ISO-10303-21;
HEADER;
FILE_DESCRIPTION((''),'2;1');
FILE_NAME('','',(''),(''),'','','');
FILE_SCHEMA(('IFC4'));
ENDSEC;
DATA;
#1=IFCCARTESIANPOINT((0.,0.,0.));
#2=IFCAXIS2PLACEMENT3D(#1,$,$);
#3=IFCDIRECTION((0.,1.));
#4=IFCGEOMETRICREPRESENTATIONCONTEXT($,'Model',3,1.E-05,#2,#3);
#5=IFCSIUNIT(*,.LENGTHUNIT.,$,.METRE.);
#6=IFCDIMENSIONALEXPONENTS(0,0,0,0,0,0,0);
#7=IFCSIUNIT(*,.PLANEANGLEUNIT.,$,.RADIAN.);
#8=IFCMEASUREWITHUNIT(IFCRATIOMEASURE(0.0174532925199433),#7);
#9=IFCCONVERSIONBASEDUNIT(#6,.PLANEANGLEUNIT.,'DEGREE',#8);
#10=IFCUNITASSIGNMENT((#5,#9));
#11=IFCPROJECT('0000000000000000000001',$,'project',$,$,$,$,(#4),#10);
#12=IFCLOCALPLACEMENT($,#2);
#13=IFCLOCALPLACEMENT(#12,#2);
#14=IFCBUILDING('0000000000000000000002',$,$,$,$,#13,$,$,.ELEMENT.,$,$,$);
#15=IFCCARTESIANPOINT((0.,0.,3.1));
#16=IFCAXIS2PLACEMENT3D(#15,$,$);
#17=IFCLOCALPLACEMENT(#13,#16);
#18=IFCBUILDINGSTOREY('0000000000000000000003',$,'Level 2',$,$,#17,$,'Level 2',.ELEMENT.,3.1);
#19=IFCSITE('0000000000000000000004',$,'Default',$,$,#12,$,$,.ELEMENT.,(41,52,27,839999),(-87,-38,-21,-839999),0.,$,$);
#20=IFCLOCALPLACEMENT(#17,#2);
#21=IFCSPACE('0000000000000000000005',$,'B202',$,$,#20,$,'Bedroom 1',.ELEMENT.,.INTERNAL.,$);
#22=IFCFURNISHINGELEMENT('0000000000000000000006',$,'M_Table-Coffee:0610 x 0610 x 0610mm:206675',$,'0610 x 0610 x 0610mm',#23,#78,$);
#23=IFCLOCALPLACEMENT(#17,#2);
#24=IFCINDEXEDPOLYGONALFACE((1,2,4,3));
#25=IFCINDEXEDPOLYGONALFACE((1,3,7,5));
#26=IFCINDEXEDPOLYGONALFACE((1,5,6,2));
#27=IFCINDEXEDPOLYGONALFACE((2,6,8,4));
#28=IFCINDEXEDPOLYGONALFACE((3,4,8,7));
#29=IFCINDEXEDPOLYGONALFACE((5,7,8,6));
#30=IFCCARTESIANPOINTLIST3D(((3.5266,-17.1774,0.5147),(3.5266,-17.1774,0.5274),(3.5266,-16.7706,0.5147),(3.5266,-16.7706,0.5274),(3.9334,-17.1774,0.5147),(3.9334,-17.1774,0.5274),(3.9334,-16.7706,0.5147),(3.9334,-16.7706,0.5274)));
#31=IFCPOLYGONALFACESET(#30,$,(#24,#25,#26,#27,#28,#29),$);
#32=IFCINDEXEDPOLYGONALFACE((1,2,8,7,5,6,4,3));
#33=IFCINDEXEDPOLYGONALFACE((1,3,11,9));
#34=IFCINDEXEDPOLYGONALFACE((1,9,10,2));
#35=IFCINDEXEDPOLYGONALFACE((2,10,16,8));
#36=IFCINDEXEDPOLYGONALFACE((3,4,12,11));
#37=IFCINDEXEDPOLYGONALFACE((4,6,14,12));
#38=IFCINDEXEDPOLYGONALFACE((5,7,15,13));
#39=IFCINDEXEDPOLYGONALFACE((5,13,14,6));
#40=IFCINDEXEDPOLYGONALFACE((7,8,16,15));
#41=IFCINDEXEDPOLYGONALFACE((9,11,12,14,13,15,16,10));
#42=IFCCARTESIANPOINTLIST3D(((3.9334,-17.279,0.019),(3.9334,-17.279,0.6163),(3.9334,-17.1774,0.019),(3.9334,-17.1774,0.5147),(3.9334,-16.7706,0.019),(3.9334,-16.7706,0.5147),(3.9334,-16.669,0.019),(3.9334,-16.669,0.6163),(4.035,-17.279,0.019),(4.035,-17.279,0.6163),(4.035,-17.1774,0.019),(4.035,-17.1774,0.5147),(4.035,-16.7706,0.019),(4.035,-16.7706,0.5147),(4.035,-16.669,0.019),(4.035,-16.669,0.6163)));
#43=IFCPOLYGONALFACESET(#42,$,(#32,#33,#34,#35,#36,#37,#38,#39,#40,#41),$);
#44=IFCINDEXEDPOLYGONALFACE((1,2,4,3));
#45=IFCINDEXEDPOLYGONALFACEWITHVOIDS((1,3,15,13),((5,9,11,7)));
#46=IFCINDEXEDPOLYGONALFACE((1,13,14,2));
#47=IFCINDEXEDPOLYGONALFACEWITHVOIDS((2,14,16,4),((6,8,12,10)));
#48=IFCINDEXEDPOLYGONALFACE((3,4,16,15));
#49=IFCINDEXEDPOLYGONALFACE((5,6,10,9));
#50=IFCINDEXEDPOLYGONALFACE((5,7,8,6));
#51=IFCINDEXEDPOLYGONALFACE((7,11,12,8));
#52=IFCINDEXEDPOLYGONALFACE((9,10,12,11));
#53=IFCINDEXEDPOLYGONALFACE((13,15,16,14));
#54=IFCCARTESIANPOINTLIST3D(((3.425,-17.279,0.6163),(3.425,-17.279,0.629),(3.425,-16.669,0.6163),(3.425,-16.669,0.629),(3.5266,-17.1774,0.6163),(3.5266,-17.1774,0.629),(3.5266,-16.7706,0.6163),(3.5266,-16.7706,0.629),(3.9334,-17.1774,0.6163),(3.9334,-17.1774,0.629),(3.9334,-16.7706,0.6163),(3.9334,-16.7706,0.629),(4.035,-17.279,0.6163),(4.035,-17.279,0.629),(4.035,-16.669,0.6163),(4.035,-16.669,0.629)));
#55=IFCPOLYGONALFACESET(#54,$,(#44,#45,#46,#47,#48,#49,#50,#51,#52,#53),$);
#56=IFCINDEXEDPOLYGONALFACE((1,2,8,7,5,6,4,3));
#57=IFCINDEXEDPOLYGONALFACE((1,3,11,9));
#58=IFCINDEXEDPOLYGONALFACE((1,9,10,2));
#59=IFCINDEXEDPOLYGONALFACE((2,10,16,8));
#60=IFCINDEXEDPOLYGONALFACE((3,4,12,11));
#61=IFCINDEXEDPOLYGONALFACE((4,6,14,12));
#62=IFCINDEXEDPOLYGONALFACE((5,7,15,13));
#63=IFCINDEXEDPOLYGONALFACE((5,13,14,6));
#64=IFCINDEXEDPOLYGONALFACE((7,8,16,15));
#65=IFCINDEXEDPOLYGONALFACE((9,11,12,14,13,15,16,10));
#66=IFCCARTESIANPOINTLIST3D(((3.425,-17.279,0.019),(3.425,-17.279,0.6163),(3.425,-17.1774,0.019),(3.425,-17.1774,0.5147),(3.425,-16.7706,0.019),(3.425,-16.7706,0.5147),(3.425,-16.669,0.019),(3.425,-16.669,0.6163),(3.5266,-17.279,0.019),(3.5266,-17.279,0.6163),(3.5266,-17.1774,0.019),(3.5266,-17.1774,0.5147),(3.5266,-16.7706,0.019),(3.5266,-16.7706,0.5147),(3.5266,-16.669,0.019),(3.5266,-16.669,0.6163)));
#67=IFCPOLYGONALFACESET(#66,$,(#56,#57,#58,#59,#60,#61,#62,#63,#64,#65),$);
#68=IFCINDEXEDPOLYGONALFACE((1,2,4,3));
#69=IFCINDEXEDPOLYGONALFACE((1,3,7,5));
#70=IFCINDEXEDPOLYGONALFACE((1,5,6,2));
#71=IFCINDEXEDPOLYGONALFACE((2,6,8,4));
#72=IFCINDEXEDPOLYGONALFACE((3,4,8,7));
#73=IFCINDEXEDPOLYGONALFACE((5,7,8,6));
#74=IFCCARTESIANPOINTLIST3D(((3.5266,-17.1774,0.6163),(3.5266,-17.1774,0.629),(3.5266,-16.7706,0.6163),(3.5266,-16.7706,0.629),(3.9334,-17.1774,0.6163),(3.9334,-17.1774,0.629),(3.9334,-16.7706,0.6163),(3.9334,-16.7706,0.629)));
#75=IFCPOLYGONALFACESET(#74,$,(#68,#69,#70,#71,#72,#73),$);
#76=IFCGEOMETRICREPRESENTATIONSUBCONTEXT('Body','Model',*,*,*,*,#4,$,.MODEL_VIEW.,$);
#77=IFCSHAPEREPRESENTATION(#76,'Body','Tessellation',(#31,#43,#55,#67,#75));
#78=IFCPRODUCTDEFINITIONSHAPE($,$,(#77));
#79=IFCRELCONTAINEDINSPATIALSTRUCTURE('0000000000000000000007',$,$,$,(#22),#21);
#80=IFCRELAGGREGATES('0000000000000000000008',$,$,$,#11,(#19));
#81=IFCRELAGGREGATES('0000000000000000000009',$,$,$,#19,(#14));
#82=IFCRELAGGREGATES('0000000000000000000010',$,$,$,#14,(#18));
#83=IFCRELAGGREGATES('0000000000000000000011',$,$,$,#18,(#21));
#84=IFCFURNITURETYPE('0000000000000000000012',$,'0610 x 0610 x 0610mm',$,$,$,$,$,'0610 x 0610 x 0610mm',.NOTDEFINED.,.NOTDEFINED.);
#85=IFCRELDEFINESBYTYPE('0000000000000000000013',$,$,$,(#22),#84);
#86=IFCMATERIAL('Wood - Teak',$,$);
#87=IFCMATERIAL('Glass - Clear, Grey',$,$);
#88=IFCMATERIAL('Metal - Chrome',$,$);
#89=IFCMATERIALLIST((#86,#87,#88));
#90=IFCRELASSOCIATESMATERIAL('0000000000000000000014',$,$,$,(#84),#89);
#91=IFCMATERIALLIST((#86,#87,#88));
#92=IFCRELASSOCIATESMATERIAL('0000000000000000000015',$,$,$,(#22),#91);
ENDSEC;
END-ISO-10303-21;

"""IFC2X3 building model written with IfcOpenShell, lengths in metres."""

from ifc_helpers import new_model, entity, si_unit, converted_unit, direction, frame, origin, origin_2d_with_axis, place, context, subcontext, project, spatial, polyline, rectangle, outline, extrude, source, transform, mapped, material, material_list, type_object, type_shapes, element, save


model = new_model("IFC2X3")

# Units and contexts
model_context = context("Model", 3, precision=1e-05, world=origin(), true_north=direction((0.0, 1.0)))
body_context = subcontext(model_context, "Body", "Model", "MODEL_VIEW")
ifc_project = project(units=[si_unit("LENGTHUNIT", "METRE"), converted_unit("PLANEANGLEUNIT", "DEGREE", entity("IfcRatioMeasure", 0.0174532925199433), si_unit("PLANEANGLEUNIT", "RADIAN"), dimensions=[0, 0, 0, 0, 0, 0, 0])], contexts=[model_context])

# Site, building, storey
site_placement = place(None, origin())
site = spatial("IfcSite", under=ifc_project, at=site_placement, Name="Default", CompositionType="ELEMENT", RefLatitude=(41, 52, 27, 839999), RefLongitude=(-87, -38, -21, -839999), RefElevation=0.0)
building_placement = place(site_placement, origin())
building = spatial("IfcBuilding", under=site, at=building_placement, CompositionType="ELEMENT")
storey_placement = place(building_placement, frame((0.0, 0.0, 3.1)))
storey = spatial("IfcBuildingStorey", under=building, at=storey_placement, Name="Level 2", LongName="Level 2", CompositionType="ELEMENT", Elevation=3.1)

# Shared definitions
space_placement = place(storey_placement, origin())
space = spatial("IfcSpace", under=storey, at=space_placement, Name="B202", LongName="Bedroom 1", CompositionType="ELEMENT", InteriorOrExteriorSpace="INTERNAL")

# Furnishing element
ifc_material_1 = material(Name="Wood - Teak")
ifc_material_2 = material(Name="Glass - Clear, Grey")
ifc_material_3 = material(Name="Metal - Chrome")
ifc_material_list_1 = material_list([ifc_material_1, ifc_material_2, ifc_material_3])
ifc_material_list_2 = material_list([ifc_material_1, ifc_material_2, ifc_material_3])
furniture_type_1 = type_object("IfcFurnitureType", Name="0610 x 0610 x 0610mm", ElementType="0610 x 0610 x 0610mm", AssemblyPlace="NOTDEFINED", material=ifc_material_list_2)
shared_shape_1 = source(origin(), body_context, "Body", "SweptSolid", [
    extrude(rectangle(XDim=0.4068, YDim=0.4068, at=origin_2d_with_axis()), frame((0.0183, 0.0952, 0.4957), z_axis=(0.0, 0.0, 1.0), x_axis=(-1.0, 0.0, 0.0)), (0.0, 0.0, 1.0), 0.0127),
    extrude(outline(polyline([(-0.2732, -0.305), (0.324, -0.305), (0.324, 0.305), (-0.2732, 0.305), (-0.2732, 0.2034), (0.2225, 0.2034), (0.2225, -0.2034), (-0.2732, -0.2034), (-0.2732, -0.305)])), frame((0.2217, 0.0952, 0.2732), z_axis=(1.0, 0.0, 0.0), x_axis=(0.0, 0.0, 1.0)), (0.0, 0.0, 1.0), 0.1016),
    extrude(outline(polyline([(-0.305, -0.305), (0.305, -0.305), (0.305, 0.305), (-0.305, 0.305), (-0.305, -0.305)]), holes=[polyline([(-0.2034, -0.2034), (-0.2034, 0.2034), (0.2034, 0.2034), (0.2034, -0.2034), (-0.2034, -0.2034)])]), frame((0.0183, 0.0952, 0.5973), z_axis=(0.0, 0.0, 1.0), x_axis=(-1.0, 0.0, 0.0)), (0.0, 0.0, 1.0), 0.0127),
    extrude(outline(polyline([(-0.305, -0.3241), (0.305, -0.3241), (0.305, 0.2733), (0.2034, 0.2733), (0.2034, -0.2224), (-0.2034, -0.2224), (-0.2034, 0.2733), (-0.305, 0.2733), (-0.305, -0.3241)])), frame((-0.2867, 0.0952, 0.2733), z_axis=(1.0, 0.0, 0.0), x_axis=(0.0, -1.0, 0.0)), (0.0, 0.0, 1.0), 0.1016),
    extrude(rectangle(XDim=0.4068, YDim=0.4068, at=origin_2d_with_axis()), frame((0.0183, 0.0952, 0.5973), z_axis=(0.0, 0.0, 1.0), x_axis=(-1.0, 0.0, 0.0)), (0.0, 0.0, 1.0), 0.0127),
])
type_shapes(furniture_type_1, [shared_shape_1])
furnishing_1_placement = place(space_placement, frame((3.7117, -17.0692, 0.019)))
element("IfcFurnishingElement", 1, at=furnishing_1_placement, inside=space, type_object=furniture_type_1, material=ifc_material_list_1, Name="M_Table-Coffee:0610 x 0610 x 0610mm:206675", ObjectType="0610 x 0610 x 0610mm", context=body_context, shape_type="MappedRepresentation", body=[
    mapped(shared_shape_1, transform((0.0, 0.0, 0.0), scale=1.0)),
])

save(model, "model.ifc")
